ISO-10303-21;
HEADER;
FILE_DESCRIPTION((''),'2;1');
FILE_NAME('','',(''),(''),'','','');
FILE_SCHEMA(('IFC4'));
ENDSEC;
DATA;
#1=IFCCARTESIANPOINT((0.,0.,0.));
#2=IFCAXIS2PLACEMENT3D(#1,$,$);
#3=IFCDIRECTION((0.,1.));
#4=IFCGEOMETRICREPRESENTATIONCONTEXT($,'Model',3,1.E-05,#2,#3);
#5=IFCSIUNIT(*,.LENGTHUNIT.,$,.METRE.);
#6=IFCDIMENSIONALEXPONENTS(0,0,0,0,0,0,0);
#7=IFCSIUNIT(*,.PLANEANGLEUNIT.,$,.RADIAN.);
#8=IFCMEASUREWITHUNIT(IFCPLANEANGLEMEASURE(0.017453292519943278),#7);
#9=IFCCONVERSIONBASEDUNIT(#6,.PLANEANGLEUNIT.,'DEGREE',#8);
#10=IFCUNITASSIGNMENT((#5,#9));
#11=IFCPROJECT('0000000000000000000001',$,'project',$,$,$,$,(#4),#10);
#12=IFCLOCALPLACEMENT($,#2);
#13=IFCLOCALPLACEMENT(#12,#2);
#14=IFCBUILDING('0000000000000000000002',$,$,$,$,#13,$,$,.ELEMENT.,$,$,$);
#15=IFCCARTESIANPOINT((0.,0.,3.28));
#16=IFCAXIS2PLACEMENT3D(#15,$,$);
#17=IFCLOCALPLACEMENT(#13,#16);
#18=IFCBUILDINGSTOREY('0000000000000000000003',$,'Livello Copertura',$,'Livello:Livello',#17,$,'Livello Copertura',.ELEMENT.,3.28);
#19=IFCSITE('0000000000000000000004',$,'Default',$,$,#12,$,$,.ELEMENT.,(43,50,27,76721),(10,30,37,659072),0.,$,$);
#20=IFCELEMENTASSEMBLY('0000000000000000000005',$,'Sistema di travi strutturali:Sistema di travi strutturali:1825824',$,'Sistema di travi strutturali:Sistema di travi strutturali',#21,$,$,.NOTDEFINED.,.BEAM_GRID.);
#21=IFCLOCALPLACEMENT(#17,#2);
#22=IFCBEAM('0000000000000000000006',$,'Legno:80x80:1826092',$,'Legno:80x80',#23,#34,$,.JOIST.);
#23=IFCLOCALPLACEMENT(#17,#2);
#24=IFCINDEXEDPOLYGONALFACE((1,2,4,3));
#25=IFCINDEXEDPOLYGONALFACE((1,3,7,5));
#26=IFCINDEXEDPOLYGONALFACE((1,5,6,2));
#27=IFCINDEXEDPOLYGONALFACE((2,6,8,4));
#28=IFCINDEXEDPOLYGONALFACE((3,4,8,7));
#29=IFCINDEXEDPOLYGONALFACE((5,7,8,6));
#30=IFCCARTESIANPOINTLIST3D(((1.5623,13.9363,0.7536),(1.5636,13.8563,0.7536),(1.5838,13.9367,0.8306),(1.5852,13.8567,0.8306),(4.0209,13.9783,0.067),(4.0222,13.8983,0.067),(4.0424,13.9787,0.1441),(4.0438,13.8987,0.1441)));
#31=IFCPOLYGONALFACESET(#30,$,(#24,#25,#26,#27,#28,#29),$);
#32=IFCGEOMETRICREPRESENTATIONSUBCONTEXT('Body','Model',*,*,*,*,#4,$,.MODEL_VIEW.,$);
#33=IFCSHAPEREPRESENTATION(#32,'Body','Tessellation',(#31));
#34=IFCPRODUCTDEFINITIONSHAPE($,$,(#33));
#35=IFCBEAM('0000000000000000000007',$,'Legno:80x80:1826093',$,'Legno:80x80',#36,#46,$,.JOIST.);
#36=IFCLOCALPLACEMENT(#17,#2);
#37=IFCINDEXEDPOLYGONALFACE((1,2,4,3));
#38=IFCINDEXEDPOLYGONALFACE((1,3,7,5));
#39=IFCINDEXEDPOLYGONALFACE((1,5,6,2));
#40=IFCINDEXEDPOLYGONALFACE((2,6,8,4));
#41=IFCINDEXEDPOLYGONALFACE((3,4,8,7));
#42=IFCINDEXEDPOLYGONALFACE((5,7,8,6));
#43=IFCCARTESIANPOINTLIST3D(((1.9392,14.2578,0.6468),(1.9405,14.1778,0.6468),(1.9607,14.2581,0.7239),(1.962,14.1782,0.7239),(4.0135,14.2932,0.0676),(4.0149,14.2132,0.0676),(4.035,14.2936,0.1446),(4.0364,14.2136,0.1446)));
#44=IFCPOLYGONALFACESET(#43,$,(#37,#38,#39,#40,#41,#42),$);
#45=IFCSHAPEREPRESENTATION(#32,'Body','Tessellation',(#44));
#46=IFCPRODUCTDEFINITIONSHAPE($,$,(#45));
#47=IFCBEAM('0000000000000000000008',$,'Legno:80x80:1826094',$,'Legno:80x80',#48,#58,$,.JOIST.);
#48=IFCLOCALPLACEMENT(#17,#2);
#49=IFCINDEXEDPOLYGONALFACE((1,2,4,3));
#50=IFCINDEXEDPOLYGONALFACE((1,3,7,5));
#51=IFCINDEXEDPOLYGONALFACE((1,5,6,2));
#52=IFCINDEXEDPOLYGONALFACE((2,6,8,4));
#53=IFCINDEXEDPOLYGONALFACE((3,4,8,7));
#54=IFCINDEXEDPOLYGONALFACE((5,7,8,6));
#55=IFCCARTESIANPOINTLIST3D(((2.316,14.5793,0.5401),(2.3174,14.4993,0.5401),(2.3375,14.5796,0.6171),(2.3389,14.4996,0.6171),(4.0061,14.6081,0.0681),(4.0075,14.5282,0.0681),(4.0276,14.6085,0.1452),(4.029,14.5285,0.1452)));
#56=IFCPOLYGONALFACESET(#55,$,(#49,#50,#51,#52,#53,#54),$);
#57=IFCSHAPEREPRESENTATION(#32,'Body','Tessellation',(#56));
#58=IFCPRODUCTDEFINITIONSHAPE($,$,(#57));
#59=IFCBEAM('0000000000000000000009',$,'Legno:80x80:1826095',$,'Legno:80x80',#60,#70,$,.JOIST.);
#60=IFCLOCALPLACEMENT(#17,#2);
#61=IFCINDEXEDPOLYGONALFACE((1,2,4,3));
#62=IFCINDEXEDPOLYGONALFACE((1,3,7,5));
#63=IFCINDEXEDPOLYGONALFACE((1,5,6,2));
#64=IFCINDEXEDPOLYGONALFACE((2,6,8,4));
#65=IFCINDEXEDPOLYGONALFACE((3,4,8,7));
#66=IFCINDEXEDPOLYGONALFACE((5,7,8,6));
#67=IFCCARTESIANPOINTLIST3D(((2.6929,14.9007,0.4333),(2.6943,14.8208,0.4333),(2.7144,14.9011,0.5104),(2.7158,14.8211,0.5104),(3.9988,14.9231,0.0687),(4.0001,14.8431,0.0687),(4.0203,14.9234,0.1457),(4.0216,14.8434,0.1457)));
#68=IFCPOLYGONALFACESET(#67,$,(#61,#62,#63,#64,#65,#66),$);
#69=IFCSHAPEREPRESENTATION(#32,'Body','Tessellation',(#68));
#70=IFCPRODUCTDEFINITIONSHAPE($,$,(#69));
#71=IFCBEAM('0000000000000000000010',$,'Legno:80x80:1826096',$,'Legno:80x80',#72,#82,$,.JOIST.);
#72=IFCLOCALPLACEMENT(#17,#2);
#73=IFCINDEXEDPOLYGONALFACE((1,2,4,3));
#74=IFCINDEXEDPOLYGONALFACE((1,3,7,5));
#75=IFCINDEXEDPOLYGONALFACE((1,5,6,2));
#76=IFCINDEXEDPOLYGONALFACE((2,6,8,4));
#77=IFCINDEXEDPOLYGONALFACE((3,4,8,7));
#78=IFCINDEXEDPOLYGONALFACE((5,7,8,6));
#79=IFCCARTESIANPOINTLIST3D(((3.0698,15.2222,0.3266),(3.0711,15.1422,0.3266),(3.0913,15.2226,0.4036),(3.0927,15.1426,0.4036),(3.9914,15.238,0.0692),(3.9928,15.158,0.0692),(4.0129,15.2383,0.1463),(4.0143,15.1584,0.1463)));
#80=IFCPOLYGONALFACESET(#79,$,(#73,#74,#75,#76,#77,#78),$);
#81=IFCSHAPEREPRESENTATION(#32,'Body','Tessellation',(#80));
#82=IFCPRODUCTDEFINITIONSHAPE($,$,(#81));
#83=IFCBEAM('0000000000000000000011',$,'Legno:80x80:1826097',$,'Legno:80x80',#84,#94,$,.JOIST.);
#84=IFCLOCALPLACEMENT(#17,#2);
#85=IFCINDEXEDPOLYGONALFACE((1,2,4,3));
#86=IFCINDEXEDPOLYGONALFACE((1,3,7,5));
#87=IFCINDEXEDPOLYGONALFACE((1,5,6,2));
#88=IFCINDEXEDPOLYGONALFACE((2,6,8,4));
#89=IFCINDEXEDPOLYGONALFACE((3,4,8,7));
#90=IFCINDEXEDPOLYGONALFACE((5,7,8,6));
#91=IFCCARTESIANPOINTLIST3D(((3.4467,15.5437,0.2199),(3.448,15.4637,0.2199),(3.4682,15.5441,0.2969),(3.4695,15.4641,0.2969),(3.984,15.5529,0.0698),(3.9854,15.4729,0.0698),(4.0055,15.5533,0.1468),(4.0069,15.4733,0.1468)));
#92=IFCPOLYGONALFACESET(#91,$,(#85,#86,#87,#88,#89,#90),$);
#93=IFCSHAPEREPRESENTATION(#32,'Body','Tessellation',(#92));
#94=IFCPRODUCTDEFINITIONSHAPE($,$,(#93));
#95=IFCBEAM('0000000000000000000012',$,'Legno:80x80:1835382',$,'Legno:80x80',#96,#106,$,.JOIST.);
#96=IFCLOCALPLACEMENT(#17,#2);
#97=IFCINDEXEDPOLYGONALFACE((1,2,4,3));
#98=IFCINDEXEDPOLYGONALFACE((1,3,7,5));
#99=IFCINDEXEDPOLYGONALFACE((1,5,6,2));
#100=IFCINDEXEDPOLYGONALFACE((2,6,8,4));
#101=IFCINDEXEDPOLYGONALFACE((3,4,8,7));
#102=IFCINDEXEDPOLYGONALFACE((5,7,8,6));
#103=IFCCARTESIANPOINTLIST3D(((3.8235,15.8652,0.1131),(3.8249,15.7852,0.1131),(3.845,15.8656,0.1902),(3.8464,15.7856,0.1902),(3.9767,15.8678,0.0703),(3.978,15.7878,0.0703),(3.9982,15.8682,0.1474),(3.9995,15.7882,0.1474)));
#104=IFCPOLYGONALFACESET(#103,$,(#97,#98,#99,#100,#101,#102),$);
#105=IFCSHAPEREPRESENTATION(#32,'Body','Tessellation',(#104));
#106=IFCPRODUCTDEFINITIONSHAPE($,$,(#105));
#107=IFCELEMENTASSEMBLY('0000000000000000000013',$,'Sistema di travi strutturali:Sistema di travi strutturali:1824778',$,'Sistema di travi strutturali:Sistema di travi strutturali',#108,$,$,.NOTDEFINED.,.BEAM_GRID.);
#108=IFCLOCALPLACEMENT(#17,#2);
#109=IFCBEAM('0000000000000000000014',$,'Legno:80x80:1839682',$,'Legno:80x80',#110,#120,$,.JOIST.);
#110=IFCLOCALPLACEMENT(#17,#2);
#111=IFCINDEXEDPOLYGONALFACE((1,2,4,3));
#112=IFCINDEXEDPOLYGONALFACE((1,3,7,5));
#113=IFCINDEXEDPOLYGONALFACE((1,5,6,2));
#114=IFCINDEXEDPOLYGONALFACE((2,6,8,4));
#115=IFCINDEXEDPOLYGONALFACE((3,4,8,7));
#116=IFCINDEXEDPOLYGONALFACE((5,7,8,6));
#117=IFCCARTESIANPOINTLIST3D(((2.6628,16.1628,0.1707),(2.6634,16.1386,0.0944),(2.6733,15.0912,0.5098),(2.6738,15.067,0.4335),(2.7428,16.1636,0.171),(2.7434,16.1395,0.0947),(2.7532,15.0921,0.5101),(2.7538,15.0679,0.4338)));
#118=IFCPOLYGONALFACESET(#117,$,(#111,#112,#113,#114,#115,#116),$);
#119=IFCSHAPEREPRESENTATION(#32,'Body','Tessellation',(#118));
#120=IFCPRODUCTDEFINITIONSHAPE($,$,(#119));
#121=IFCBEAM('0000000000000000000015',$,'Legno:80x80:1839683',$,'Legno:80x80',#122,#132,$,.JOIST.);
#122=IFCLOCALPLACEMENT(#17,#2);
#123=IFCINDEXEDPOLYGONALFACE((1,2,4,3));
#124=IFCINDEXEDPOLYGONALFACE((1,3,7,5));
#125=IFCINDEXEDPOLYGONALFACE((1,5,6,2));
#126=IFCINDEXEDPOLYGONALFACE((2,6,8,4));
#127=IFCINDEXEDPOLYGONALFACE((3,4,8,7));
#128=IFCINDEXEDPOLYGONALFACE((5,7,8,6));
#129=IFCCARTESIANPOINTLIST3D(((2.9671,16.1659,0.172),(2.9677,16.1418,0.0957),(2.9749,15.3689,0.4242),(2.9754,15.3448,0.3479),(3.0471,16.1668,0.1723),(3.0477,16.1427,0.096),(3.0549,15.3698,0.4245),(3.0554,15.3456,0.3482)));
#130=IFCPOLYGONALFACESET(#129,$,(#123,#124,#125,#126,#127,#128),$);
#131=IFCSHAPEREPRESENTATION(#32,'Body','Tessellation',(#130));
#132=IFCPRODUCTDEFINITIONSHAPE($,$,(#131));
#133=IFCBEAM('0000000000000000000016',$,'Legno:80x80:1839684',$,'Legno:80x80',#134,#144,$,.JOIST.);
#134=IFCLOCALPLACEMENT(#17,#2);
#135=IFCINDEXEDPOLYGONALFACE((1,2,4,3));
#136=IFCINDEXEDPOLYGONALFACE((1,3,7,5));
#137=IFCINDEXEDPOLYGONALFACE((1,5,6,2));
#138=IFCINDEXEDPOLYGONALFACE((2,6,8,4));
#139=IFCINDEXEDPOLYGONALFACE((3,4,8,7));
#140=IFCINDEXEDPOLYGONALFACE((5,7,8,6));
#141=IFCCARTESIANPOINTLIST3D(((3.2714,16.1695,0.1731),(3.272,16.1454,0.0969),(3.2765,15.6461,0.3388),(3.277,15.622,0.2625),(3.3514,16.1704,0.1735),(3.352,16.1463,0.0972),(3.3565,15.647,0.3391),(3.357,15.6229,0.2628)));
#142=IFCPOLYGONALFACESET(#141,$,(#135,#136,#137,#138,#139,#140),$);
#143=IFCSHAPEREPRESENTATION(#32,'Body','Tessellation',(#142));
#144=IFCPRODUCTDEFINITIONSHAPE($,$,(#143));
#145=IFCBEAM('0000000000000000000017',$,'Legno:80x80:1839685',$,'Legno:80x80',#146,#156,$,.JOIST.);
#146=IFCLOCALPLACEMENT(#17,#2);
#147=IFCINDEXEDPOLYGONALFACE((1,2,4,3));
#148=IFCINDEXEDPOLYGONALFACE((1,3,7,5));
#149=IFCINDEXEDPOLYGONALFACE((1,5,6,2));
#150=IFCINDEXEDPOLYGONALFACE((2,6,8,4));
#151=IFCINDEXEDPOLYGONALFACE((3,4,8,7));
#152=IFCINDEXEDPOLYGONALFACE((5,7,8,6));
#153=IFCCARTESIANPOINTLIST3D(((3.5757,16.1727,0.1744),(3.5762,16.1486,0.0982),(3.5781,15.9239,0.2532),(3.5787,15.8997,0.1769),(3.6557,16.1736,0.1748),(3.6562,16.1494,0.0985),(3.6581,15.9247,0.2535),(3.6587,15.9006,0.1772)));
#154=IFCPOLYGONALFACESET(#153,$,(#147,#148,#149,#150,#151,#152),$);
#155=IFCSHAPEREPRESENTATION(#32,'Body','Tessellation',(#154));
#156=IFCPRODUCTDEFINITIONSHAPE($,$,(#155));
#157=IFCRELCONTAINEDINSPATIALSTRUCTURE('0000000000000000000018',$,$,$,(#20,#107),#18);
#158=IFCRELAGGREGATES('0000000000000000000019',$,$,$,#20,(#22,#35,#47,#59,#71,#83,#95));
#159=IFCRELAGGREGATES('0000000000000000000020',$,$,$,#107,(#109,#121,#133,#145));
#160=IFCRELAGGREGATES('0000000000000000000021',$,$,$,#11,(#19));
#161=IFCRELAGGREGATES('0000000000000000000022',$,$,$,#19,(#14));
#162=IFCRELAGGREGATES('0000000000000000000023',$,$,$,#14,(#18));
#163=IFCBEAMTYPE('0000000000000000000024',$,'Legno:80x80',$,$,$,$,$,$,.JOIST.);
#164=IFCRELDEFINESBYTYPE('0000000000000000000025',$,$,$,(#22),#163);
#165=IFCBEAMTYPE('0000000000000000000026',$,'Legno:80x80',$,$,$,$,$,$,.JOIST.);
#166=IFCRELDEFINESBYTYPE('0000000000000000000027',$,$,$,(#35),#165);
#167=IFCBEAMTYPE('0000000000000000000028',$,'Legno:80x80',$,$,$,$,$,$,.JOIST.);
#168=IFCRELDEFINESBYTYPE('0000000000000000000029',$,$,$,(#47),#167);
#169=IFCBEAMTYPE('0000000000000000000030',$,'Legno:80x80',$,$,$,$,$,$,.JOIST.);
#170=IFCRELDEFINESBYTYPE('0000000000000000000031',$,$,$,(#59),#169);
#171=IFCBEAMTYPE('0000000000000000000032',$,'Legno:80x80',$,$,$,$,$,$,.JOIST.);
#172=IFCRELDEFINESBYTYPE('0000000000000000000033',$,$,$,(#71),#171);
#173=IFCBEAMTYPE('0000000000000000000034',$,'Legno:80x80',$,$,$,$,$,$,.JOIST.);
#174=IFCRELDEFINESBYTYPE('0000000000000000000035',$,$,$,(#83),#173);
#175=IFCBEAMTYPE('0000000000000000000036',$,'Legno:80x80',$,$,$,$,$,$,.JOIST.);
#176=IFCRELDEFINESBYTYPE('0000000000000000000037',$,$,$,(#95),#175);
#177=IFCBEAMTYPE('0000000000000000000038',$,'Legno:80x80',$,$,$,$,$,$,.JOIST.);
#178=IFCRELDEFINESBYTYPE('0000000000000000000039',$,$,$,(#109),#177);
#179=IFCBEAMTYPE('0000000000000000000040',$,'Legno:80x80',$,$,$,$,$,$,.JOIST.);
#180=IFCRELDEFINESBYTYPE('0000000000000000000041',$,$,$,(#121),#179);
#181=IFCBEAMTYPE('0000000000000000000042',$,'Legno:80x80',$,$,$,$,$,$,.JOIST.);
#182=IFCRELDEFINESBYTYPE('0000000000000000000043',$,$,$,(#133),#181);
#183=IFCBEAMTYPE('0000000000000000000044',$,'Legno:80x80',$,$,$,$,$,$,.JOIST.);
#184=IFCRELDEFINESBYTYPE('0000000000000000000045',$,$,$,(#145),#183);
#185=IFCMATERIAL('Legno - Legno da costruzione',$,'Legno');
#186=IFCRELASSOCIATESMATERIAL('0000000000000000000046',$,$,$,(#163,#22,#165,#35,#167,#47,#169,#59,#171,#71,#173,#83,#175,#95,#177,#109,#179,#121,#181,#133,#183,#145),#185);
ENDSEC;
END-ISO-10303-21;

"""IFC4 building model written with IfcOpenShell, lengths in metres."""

from ifc_helpers import new_model, entity, si_unit, converted_unit, direction, frame, origin, place, context, subcontext, project, spatial, indexed_curve, outline, extrude, source, transform, mapped, material, type_object, type_shapes, element, aggregate, save


model = new_model("IFC4")

# Units and contexts
model_context = context("Model", 3, precision=1e-05, world=origin(), true_north=direction((0.0, 1.0)))
body_context = subcontext(model_context, "Body", "Model", "MODEL_VIEW")
ifc_project = project(units=[si_unit("LENGTHUNIT", "METRE"), converted_unit("PLANEANGLEUNIT", "DEGREE", entity("IfcPlaneAngleMeasure", 0.017453292519943278), si_unit("PLANEANGLEUNIT", "RADIAN"), dimensions=[0, 0, 0, 0, 0, 0, 0])], contexts=[model_context])

# Site, building, storey
site_placement = place(None, origin())
site = spatial("IfcSite", under=ifc_project, at=site_placement, Name="Default", CompositionType="ELEMENT", RefLatitude=(43, 50, 27, 76721), RefLongitude=(10, 30, 37, 659072), RefElevation=0.0)
building_placement = place(site_placement, origin())
building = spatial("IfcBuilding", under=site, at=building_placement, CompositionType="ELEMENT")
storey_placement = place(building_placement, frame((0.0, 0.0, 3.28)))
storey = spatial("IfcBuildingStorey", under=building, at=storey_placement, Name="Livello Copertura", ObjectType="Livello:Livello", LongName="Livello Copertura", CompositionType="ELEMENT", Elevation=3.28)

# Element assemblies, beams
assembly_1_placement = place(storey_placement, origin())
assembly_1 = element("IfcElementAssembly", 1, at=assembly_1_placement, inside=storey, Name="Sistema di travi strutturali:Sistema di travi strutturali:1825824", ObjectType="Sistema di travi strutturali:Sistema di travi strutturali", AssemblyPlace="NOTDEFINED", PredefinedType="BEAM_GRID")
ifc_material = material(Name="Legno - Legno da costruzione", Category="Legno")
beam_type_1 = type_object("IfcBeamType", Name="Legno:80x80", PredefinedType="JOIST", material=ifc_material)
shared_shape_1 = source(origin(), body_context, "Body", "SweptSolid", [
    extrude(outline(indexed_curve([(-1.2765, -0.04), (1.2765, -0.04), (1.2765, 0.04), (-1.2765, 0.04), (-1.2765, -0.04)], self_intersect=False)), frame((0.0, 0.0, -0.04), z_axis=(0.0, 0.0, 1.0), x_axis=(-1.0, 0.0, 0.0)), (0.0, 0.0, 1.0), 0.08),
])
type_shapes(beam_type_1, [shared_shape_1])
beam_1_placement = place(assembly_1_placement, frame((2.803, 13.9175, 0.4488), z_axis=(0.268881, 0.004594, 0.963163), x_axis=(-0.963022, -0.016456, 0.26892)))
beam_1 = element("IfcBeam", 2, at=beam_1_placement, type_object=beam_type_1, material=ifc_material, Name="Legno:80x80:1826092", ObjectType="Legno:80x80", PredefinedType="JOIST", context=body_context, shape_type="MappedRepresentation", body=[
    mapped(shared_shape_1, transform((0.0, 0.0, 0.0), scale=1.0)),
])
beam_type_2 = type_object("IfcBeamType", Name="Legno:80x80", PredefinedType="JOIST", material=ifc_material)
shared_shape_2 = source(origin(), body_context, "Body", "SweptSolid", [
    extrude(outline(indexed_curve([(-1.077, -0.04), (1.077, -0.04), (1.077, 0.04), (-1.077, 0.04), (-1.077, -0.04)], self_intersect=False)), frame((0.0, 0.0, -0.04), z_axis=(0.0, 0.0, 1.0), x_axis=(-1.0, 0.0, 0.0)), (0.0, 0.0, 1.0), 0.08),
])
type_shapes(beam_type_2, [shared_shape_2])
beam_2_placement = place(assembly_1_placement, frame((2.9878, 14.2357, 0.3957), z_axis=(0.268881, 0.004594, 0.963163), x_axis=(-0.963022, -0.016456, 0.26892)))
beam_2 = element("IfcBeam", 3, at=beam_2_placement, type_object=beam_type_2, material=ifc_material, Name="Legno:80x80:1826093", ObjectType="Legno:80x80", PredefinedType="JOIST", context=body_context, shape_type="MappedRepresentation", body=[
    mapped(shared_shape_2, transform((0.0, 0.0, 0.0), scale=1.0)),
])
beam_type_3 = type_object("IfcBeamType", Name="Legno:80x80", PredefinedType="JOIST", material=ifc_material)
shared_shape_3 = source(origin(), body_context, "Body", "SweptSolid", [
    extrude(outline(indexed_curve([(-0.8775, -0.04), (0.8775, -0.04), (0.8775, 0.04), (-0.8775, 0.04), (-0.8775, -0.04)], self_intersect=False)), frame((0.0, 0.0, -0.04), z_axis=(0.0, 0.0, 1.0), x_axis=(-1.0, 0.0, 0.0)), (0.0, 0.0, 1.0), 0.08),
])
type_shapes(beam_type_3, [shared_shape_3])
beam_3_placement = place(assembly_1_placement, frame((3.1725, 14.5539, 0.3426), z_axis=(0.268881, 0.004594, 0.963163), x_axis=(-0.963022, -0.016456, 0.26892)))
beam_3 = element("IfcBeam", 4, at=beam_3_placement, type_object=beam_type_3, material=ifc_material, Name="Legno:80x80:1826094", ObjectType="Legno:80x80", PredefinedType="JOIST", context=body_context, shape_type="MappedRepresentation", body=[
    mapped(shared_shape_3, transform((0.0, 0.0, 0.0), scale=1.0)),
])
beam_type_4 = type_object("IfcBeamType", Name="Legno:80x80", PredefinedType="JOIST", material=ifc_material)
shared_shape_4 = source(origin(), body_context, "Body", "SweptSolid", [
    extrude(outline(indexed_curve([(-0.678, -0.04), (0.678, -0.04), (0.678, 0.04), (-0.678, 0.04), (-0.678, -0.04)], self_intersect=False)), frame((0.0, 0.0, -0.04), z_axis=(0.0, 0.0, 1.0), x_axis=(-1.0, 0.0, 0.0)), (0.0, 0.0, 1.0), 0.08),
])
type_shapes(beam_type_4, [shared_shape_4])
beam_4_placement = place(assembly_1_placement, frame((3.3573, 14.8721, 0.2895), z_axis=(0.268881, 0.004594, 0.963163), x_axis=(-0.963022, -0.016456, 0.26892)))
beam_4 = element("IfcBeam", 5, at=beam_4_placement, type_object=beam_type_4, material=ifc_material, Name="Legno:80x80:1826095", ObjectType="Legno:80x80", PredefinedType="JOIST", context=body_context, shape_type="MappedRepresentation", body=[
    mapped(shared_shape_4, transform((0.0, 0.0, 0.0), scale=1.0)),
])
beam_type_5 = type_object("IfcBeamType", Name="Legno:80x80", PredefinedType="JOIST", material=ifc_material)
shared_shape_5 = source(origin(), body_context, "Body", "SweptSolid", [
    extrude(outline(indexed_curve([(-0.4785, -0.04), (0.4785, -0.04), (0.4785, 0.04), (-0.4785, 0.04), (-0.4785, -0.04)], self_intersect=False)), frame((0.0, 0.0, -0.04), z_axis=(0.0, 0.0, 1.0), x_axis=(-1.0, 0.0, 0.0)), (0.0, 0.0, 1.0), 0.08),
])
type_shapes(beam_type_5, [shared_shape_5])
beam_5_placement = place(assembly_1_placement, frame((3.542, 15.1903, 0.2364), z_axis=(0.268881, 0.004594, 0.963163), x_axis=(-0.963022, -0.016456, 0.26892)))
beam_5 = element("IfcBeam", 6, at=beam_5_placement, type_object=beam_type_5, material=ifc_material, Name="Legno:80x80:1826096", ObjectType="Legno:80x80", PredefinedType="JOIST", context=body_context, shape_type="MappedRepresentation", body=[
    mapped(shared_shape_5, transform((0.0, 0.0, 0.0), scale=1.0)),
])
beam_type_6 = type_object("IfcBeamType", Name="Legno:80x80", PredefinedType="JOIST", material=ifc_material)
shared_shape_6 = source(origin(), body_context, "Body", "SweptSolid", [
    extrude(outline(indexed_curve([(-0.279, -0.04), (0.279, -0.04), (0.279, 0.04), (-0.279, 0.04), (-0.279, -0.04)], self_intersect=False)), frame((0.0, 0.0, -0.04), z_axis=(0.0, 0.0, 1.0), x_axis=(-1.0, 0.0, 0.0)), (0.0, 0.0, 1.0), 0.08),
])
type_shapes(beam_type_6, [shared_shape_6])
beam_6_placement = place(assembly_1_placement, frame((3.7268, 15.5085, 0.1833), z_axis=(0.268881, 0.004594, 0.963163), x_axis=(-0.963022, -0.016456, 0.26892)))
beam_6 = element("IfcBeam", 7, at=beam_6_placement, type_object=beam_type_6, material=ifc_material, Name="Legno:80x80:1826097", ObjectType="Legno:80x80", PredefinedType="JOIST", context=body_context, shape_type="MappedRepresentation", body=[
    mapped(shared_shape_6, transform((0.0, 0.0, 0.0), scale=1.0)),
])
beam_type_7 = type_object("IfcBeamType", Name="Legno:80x80", PredefinedType="JOIST", material=ifc_material)
shared_shape_7 = source(origin(), body_context, "Body", "SweptSolid", [
    extrude(outline(indexed_curve([(-0.0795, -0.04), (0.0795, -0.04), (0.0795, 0.04), (-0.0795, 0.04), (-0.0795, -0.04)], self_intersect=False)), frame((0.0, 0.0, -0.04), z_axis=(0.0, 0.0, 1.0), x_axis=(-1.0, 0.0, 0.0)), (0.0, 0.0, 1.0), 0.08),
])
type_shapes(beam_type_7, [shared_shape_7])
beam_7_placement = place(assembly_1_placement, frame((3.9115, 15.8267, 0.1303), z_axis=(0.268881, 0.004594, 0.963163), x_axis=(-0.963022, -0.016456, 0.26892)))
beam_7 = element("IfcBeam", 8, at=beam_7_placement, type_object=beam_type_7, material=ifc_material, Name="Legno:80x80:1835382", ObjectType="Legno:80x80", PredefinedType="JOIST", context=body_context, shape_type="MappedRepresentation", body=[
    mapped(shared_shape_7, transform((0.0, 0.0, 0.0), scale=1.0)),
])
aggregate(assembly_1, [beam_1, beam_2, beam_3, beam_4, beam_5, beam_6, beam_7])
assembly_2_placement = place(storey_placement, origin())
assembly_2 = element("IfcElementAssembly", 9, at=assembly_2_placement, inside=storey, Name="Sistema di travi strutturali:Sistema di travi strutturali:1824778", ObjectType="Sistema di travi strutturali:Sistema di travi strutturali", AssemblyPlace="NOTDEFINED", PredefinedType="BEAM_GRID")
beam_type_8 = type_object("IfcBeamType", Name="Legno:80x80", PredefinedType="JOIST", material=ifc_material)
shared_shape_8 = source(origin(), body_context, "Body", "SweptSolid", [
    extrude(outline(indexed_curve([(-0.562, -0.04), (0.562, -0.04), (0.562, 0.04), (-0.562, 0.04), (-0.562, -0.04)], self_intersect=False)), frame((0.0, 0.0, -0.04), z_axis=(0.0, 0.0, 1.0), x_axis=(-1.0, 0.0, 0.0)), (0.0, 0.0, 1.0), 0.08),
])
type_shapes(beam_type_8, [shared_shape_8])
beam_8_placement = place(assembly_2_placement, frame((2.7083, 15.6153, 0.3023), z_axis=(-0.007187, 0.301619, 0.953402), x_axis=(0.009277, -0.953365, 0.301677)))
beam_8 = element("IfcBeam", 10, at=beam_8_placement, type_object=beam_type_8, material=ifc_material, Name="Legno:80x80:1839682", ObjectType="Legno:80x80", PredefinedType="JOIST", context=body_context, shape_type="MappedRepresentation", body=[
    mapped(shared_shape_8, transform((0.0, 0.0, 0.0), scale=1.0)),
])
beam_type_9 = type_object("IfcBeamType", Name="Legno:80x80", PredefinedType="JOIST", material=ifc_material)
shared_shape_9 = source(origin(), body_context, "Body", "SweptSolid", [
    extrude(outline(indexed_curve([(-0.418, -0.04), (0.418, -0.04), (0.418, 0.04), (-0.418, 0.04), (-0.418, -0.04)], self_intersect=False)), frame((0.0, 0.0, -0.04), z_axis=(0.0, 0.0, 1.0), x_axis=(-1.0, 0.0, 0.0)), (0.0, 0.0, 1.0), 0.08),
])
type_shapes(beam_type_9, [shared_shape_9])
beam_9_placement = place(assembly_2_placement, frame((3.0113, 15.7558, 0.2601), z_axis=(-0.007187, 0.301619, 0.953402), x_axis=(0.009277, -0.953365, 0.301677)))
beam_9 = element("IfcBeam", 11, at=beam_9_placement, type_object=beam_type_9, material=ifc_material, Name="Legno:80x80:1839683", ObjectType="Legno:80x80", PredefinedType="JOIST", context=body_context, shape_type="MappedRepresentation", body=[
    mapped(shared_shape_9, transform((0.0, 0.0, 0.0), scale=1.0)),
])
beam_type_10 = type_object("IfcBeamType", Name="Legno:80x80", PredefinedType="JOIST", material=ifc_material)
shared_shape_10 = source(origin(), body_context, "Body", "SweptSolid", [
    extrude(outline(indexed_curve([(-0.2745, -0.04), (0.2745, -0.04), (0.2745, 0.04), (-0.2745, 0.04), (-0.2745, -0.04)], self_intersect=False)), frame((0.0, 0.0, -0.04), z_axis=(0.0, 0.0, 1.0), x_axis=(-1.0, 0.0, 0.0)), (0.0, 0.0, 1.0), 0.08),
])
type_shapes(beam_type_10, [shared_shape_10])
beam_10_placement = place(assembly_2_placement, frame((3.3142, 15.8962, 0.218), z_axis=(-0.007187, 0.301619, 0.953402), x_axis=(0.009277, -0.953365, 0.301677)))
beam_10 = element("IfcBeam", 12, at=beam_10_placement, type_object=beam_type_10, material=ifc_material, Name="Legno:80x80:1839684", ObjectType="Legno:80x80", PredefinedType="JOIST", context=body_context, shape_type="MappedRepresentation", body=[
    mapped(shared_shape_10, transform((0.0, 0.0, 0.0), scale=1.0)),
])
beam_type_11 = type_object("IfcBeamType", Name="Legno:80x80", PredefinedType="JOIST", material=ifc_material)
shared_shape_11 = source(origin(), body_context, "Body", "SweptSolid", [
    extrude(outline(indexed_curve([(-0.1305, -0.04), (0.1305, -0.04), (0.1305, 0.04), (-0.1305, 0.04), (-0.1305, -0.04)], self_intersect=False)), frame((0.0, 0.0, -0.04), z_axis=(0.0, 0.0, 1.0), x_axis=(-1.0, 0.0, 0.0)), (0.0, 0.0, 1.0), 0.08),
])
type_shapes(beam_type_11, [shared_shape_11])
beam_11_placement = place(assembly_2_placement, frame((3.6172, 16.0366, 0.1758), z_axis=(-0.007187, 0.301619, 0.953402), x_axis=(0.009277, -0.953365, 0.301677)))
beam_11 = element("IfcBeam", 13, at=beam_11_placement, type_object=beam_type_11, material=ifc_material, Name="Legno:80x80:1839685", ObjectType="Legno:80x80", PredefinedType="JOIST", context=body_context, shape_type="MappedRepresentation", body=[
    mapped(shared_shape_11, transform((0.0, 0.0, 0.0), scale=1.0)),
])
aggregate(assembly_2, [beam_8, beam_9, beam_10, beam_11])

save(model, "model.ifc")
